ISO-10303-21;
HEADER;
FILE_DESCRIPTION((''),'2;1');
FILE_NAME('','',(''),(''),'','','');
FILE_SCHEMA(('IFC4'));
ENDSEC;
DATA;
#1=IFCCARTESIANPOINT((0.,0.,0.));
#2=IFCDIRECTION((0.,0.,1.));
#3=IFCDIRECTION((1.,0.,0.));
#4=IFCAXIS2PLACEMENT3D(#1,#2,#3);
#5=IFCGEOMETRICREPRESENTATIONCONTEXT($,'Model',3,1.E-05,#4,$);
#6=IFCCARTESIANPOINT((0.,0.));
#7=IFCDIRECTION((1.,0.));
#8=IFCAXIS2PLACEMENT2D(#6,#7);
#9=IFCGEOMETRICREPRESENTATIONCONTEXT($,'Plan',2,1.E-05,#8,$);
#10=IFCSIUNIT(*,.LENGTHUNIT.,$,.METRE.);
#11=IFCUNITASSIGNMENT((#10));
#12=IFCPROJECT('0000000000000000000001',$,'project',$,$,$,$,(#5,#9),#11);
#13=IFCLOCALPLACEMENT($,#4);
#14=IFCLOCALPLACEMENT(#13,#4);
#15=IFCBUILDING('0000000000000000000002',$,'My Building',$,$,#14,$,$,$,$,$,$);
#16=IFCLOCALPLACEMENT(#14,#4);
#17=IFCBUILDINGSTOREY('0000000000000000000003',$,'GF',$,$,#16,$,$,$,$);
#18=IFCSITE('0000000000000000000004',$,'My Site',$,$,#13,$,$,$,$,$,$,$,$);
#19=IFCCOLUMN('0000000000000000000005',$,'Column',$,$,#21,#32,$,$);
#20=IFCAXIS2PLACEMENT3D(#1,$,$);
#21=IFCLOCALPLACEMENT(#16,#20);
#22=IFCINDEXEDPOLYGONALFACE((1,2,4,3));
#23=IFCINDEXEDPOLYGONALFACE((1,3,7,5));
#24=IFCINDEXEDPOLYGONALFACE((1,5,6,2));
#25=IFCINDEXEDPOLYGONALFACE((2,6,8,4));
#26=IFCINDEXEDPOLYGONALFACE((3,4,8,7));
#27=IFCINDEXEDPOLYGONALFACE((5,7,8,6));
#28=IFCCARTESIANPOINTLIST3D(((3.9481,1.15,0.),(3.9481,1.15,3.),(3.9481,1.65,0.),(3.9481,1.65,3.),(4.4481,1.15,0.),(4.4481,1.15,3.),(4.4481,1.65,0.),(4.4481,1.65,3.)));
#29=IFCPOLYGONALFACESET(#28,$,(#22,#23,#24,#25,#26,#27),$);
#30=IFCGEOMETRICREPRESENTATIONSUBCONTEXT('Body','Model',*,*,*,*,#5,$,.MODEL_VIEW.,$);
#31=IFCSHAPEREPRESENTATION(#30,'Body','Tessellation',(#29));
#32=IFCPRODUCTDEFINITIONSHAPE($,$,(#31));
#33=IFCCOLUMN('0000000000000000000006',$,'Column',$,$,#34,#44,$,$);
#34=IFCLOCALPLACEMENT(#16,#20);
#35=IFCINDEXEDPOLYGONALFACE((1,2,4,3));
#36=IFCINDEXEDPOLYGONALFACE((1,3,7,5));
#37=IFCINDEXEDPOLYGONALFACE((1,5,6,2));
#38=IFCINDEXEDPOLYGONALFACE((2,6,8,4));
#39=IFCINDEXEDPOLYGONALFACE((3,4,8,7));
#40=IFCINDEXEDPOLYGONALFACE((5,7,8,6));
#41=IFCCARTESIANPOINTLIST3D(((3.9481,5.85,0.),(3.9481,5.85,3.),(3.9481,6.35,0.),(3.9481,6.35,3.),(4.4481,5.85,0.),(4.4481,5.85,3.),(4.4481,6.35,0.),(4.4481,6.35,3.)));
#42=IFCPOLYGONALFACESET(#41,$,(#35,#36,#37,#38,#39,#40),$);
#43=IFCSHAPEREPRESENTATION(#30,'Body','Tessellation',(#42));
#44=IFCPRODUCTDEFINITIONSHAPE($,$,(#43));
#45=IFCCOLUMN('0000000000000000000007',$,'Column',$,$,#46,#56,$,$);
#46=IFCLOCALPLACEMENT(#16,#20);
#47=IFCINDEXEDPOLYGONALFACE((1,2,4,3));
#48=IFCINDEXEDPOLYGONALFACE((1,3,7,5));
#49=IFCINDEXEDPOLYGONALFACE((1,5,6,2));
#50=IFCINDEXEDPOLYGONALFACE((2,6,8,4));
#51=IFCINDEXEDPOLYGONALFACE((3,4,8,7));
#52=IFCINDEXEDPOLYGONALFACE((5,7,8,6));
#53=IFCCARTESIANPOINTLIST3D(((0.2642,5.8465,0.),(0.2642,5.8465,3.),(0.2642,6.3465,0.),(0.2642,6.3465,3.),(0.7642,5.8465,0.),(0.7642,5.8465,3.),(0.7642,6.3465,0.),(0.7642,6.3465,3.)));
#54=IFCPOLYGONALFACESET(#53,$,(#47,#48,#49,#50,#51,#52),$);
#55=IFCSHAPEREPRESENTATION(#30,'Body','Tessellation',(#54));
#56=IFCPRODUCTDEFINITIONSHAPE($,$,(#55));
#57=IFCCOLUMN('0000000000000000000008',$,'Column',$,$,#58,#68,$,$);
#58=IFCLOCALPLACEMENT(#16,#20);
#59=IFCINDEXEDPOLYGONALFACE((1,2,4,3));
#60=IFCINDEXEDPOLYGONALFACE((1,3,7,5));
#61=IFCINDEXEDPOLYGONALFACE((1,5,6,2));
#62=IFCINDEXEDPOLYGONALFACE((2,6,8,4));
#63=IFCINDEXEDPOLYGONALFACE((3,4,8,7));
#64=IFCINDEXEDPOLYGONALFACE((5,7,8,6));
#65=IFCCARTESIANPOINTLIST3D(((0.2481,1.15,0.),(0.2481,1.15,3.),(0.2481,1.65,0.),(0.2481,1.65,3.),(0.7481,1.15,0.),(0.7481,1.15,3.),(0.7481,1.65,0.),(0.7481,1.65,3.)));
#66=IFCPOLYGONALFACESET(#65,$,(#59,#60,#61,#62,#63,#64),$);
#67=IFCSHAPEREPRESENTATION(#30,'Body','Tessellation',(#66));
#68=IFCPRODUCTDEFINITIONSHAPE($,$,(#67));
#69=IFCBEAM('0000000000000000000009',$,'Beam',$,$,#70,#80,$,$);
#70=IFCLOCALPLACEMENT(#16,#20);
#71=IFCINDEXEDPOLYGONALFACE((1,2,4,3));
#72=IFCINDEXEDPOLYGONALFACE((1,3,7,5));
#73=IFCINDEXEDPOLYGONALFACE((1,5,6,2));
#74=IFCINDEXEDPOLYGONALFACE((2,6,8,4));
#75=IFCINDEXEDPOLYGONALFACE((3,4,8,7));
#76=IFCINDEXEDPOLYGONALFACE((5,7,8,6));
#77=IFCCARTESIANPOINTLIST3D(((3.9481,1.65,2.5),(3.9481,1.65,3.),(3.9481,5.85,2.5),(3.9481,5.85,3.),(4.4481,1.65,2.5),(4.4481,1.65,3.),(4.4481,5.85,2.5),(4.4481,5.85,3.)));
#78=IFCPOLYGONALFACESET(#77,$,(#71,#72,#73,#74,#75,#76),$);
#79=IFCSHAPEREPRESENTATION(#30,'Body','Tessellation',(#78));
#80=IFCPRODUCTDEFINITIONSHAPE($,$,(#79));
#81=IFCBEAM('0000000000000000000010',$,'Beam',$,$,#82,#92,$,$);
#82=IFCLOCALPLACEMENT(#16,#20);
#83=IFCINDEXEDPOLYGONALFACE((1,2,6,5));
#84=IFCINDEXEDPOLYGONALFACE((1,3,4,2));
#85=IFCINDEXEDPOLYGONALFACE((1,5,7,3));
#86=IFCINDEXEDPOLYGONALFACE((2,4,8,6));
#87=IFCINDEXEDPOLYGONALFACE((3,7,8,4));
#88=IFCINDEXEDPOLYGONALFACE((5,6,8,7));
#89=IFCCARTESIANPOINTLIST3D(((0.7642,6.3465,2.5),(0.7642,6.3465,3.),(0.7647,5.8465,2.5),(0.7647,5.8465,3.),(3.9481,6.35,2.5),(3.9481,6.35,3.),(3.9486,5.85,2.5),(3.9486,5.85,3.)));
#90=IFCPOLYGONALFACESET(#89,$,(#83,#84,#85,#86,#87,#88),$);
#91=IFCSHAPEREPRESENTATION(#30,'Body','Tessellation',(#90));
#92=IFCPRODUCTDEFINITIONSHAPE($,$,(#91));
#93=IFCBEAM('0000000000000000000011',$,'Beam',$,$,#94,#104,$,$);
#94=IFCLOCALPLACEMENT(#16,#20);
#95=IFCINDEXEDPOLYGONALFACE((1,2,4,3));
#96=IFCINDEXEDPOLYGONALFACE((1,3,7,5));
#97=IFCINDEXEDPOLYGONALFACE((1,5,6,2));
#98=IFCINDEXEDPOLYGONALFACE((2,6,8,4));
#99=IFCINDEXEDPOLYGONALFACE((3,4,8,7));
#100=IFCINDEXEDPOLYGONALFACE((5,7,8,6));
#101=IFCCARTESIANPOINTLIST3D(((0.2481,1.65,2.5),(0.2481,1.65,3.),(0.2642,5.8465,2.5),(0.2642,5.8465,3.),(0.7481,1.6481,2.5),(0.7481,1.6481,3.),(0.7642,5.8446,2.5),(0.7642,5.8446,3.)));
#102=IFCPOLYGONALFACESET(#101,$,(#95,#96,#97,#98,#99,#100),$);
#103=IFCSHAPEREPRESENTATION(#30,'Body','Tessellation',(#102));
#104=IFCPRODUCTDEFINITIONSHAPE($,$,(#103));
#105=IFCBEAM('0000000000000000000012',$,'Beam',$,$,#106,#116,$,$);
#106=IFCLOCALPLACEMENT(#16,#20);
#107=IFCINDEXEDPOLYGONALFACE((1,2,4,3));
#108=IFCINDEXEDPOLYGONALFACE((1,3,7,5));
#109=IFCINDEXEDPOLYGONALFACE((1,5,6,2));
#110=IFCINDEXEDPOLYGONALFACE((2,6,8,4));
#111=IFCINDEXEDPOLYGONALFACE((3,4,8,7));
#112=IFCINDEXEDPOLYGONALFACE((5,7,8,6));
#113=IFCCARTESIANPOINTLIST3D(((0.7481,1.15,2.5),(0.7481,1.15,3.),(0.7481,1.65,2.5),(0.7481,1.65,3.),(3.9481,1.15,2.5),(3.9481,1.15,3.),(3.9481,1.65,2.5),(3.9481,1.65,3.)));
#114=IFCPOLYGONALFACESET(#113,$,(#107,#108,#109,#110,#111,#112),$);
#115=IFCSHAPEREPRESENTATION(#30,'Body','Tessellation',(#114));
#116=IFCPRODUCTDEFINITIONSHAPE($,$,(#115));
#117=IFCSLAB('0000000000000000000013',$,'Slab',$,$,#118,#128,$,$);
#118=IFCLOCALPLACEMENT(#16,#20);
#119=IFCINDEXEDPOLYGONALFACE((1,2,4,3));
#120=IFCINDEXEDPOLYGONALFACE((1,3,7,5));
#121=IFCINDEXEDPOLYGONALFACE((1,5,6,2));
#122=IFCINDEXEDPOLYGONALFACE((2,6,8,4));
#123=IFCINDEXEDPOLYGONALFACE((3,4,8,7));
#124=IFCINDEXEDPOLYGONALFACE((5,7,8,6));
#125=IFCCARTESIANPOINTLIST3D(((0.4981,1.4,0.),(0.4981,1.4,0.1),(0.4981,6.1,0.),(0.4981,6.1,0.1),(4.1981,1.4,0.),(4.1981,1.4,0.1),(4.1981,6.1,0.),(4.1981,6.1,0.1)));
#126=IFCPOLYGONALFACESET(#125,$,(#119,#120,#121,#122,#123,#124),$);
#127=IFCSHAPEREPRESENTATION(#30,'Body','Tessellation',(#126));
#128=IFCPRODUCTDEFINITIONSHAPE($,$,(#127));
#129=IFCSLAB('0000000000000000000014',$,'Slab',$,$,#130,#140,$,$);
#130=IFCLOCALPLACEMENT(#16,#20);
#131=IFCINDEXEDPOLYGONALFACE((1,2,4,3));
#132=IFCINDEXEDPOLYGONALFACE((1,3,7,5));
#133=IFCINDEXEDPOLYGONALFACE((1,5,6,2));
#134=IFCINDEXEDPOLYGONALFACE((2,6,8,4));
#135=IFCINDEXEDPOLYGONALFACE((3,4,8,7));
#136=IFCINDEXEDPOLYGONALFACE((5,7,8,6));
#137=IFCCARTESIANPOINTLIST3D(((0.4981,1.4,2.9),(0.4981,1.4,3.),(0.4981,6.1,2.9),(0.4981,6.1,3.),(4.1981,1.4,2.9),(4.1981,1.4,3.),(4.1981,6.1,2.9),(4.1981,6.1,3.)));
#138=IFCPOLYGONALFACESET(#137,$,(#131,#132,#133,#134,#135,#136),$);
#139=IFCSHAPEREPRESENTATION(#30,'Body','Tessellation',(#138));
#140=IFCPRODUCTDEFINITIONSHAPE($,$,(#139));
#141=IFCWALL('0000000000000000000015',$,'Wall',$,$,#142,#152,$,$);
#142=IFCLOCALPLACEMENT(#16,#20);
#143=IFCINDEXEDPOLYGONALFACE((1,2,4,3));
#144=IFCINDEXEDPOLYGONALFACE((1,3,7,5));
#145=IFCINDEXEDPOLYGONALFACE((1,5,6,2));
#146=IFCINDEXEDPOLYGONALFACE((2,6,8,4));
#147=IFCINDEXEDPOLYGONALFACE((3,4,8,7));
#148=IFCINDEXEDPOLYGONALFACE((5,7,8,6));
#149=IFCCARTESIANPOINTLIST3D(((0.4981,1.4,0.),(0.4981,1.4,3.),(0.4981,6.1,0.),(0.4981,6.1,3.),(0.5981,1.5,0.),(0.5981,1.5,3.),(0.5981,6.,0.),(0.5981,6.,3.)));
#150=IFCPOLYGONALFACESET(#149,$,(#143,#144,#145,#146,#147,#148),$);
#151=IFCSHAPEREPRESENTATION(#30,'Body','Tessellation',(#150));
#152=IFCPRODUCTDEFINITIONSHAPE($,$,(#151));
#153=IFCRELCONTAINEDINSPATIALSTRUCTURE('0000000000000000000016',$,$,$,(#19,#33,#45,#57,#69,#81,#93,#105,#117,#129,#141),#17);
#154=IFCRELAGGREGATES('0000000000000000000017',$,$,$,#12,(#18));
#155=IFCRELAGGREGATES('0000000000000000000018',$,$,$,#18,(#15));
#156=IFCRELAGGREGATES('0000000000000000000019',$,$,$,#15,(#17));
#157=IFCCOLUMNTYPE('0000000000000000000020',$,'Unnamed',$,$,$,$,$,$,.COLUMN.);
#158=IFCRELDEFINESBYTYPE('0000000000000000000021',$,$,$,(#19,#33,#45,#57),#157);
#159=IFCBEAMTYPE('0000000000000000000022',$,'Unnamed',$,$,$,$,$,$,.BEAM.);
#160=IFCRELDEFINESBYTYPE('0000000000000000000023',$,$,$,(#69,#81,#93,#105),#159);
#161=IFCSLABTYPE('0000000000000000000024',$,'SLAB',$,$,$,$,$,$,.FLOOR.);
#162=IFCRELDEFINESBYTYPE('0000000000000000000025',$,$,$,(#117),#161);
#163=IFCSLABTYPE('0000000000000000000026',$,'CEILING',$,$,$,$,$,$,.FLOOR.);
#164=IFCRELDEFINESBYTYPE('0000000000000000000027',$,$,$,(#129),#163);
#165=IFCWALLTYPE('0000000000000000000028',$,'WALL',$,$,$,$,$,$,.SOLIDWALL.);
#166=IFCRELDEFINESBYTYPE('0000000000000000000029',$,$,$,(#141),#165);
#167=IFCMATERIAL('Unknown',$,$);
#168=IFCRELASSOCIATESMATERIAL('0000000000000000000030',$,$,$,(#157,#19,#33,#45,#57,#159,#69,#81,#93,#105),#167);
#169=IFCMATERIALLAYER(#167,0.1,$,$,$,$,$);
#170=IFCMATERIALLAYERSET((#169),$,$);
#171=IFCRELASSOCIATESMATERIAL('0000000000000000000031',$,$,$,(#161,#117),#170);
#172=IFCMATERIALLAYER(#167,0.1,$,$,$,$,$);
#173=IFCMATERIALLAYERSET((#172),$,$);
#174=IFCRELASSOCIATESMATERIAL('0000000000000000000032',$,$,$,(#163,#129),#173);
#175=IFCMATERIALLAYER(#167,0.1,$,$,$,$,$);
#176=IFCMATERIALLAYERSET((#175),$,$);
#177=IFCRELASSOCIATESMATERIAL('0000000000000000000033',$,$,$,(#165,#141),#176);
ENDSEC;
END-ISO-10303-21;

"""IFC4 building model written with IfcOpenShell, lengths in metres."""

from ifc_helpers import new_model, si_unit, frame, origin_with_axes, origin_2d_with_axis, place, context, subcontext, project, spatial, line, indexed_curve, rectangle, outline, extrude, material, layer, layer_set, layer_usage, material_profile, profile_set, profile_usage, type_object, element, save


model = new_model("IFC4")

# Units and contexts
model_context = context("Model", 3, precision=1e-05, world=origin_with_axes())
plan_context = context("Plan", 2, precision=1e-05, world=origin_2d_with_axis())
body_context_1 = subcontext(model_context, "Body", "Model", "MODEL_VIEW")
ifc_project = project(units=[si_unit("LENGTHUNIT", "METRE")], contexts=[model_context, plan_context])

# Site, building, storey
site_placement = place(None, origin_with_axes())
site = spatial("IfcSite", under=ifc_project, at=site_placement, Name="My Site")
building_placement = place(site_placement, origin_with_axes())
building = spatial("IfcBuilding", under=site, at=building_placement, Name="My Building")
storey_placement = place(building_placement, origin_with_axes())
storey = spatial("IfcBuildingStorey", under=building, at=storey_placement, Name="GF")

# Columns
ifc_material = material(Name="Unknown")
ifc_material_profile_1 = material_profile(ifc_material, rectangle(XDim=0.5, YDim=0.5))
ifc_profile_set_1 = profile_set([ifc_material_profile_1])
ifc_profile_usage_1 = profile_usage(ifc_profile_set_1, cardinal=5)
column_type = type_object("IfcColumnType", Name="Unnamed", PredefinedType="COLUMN", material=ifc_profile_set_1)
column_1_placement = place(storey_placement, frame((4.1981, 1.4, 0.0), z_axis=(0.0, 0.0, 1.0), x_axis=(1.0, 0.0, 0.0)))
element("IfcColumn", 1, at=column_1_placement, inside=storey, type_object=column_type, material=ifc_profile_usage_1, Name="Column", context=body_context_1, shape_type="SweptSolid", body=[
    extrude(rectangle(XDim=0.5, YDim=0.5), origin_with_axes(), (0.0, 0.0, 1.0), 3.0),
])
ifc_profile_usage_2 = profile_usage(ifc_profile_set_1, cardinal=5)
column_2_placement = place(storey_placement, frame((4.1981, 6.1, 0.0), z_axis=(0.0, 0.0, 1.0), x_axis=(1.0, 0.0, 0.0)))
element("IfcColumn", 2, at=column_2_placement, inside=storey, type_object=column_type, material=ifc_profile_usage_2, Name="Column", context=body_context_1, shape_type="SweptSolid", body=[
    extrude(rectangle(XDim=0.5, YDim=0.5), origin_with_axes(), (0.0, 0.0, 1.0), 3.0),
])
ifc_profile_usage_3 = profile_usage(ifc_profile_set_1, cardinal=5)
column_3_placement = place(storey_placement, frame((0.5142, 6.0965, 0.0), z_axis=(0.0, 0.0, 1.0), x_axis=(1.0, 0.0, 0.0)))
element("IfcColumn", 3, at=column_3_placement, inside=storey, type_object=column_type, material=ifc_profile_usage_3, Name="Column", context=body_context_1, shape_type="SweptSolid", body=[
    extrude(rectangle(XDim=0.5, YDim=0.5), origin_with_axes(), (0.0, 0.0, 1.0), 3.0),
])
ifc_profile_usage_4 = profile_usage(ifc_profile_set_1, cardinal=5)
column_4_placement = place(storey_placement, frame((0.4981, 1.4, 0.0), z_axis=(0.0, 0.0, 1.0), x_axis=(1.0, 0.0, 0.0)))
element("IfcColumn", 4, at=column_4_placement, inside=storey, type_object=column_type, material=ifc_profile_usage_4, Name="Column", context=body_context_1, shape_type="SweptSolid", body=[
    extrude(rectangle(XDim=0.5, YDim=0.5), origin_with_axes(), (0.0, 0.0, 1.0), 3.0),
])

# Beams
ifc_material_profile_2 = material_profile(ifc_material, rectangle(XDim=0.5, YDim=0.5))
ifc_profile_set_2 = profile_set([ifc_material_profile_2])
ifc_profile_usage_5 = profile_usage(ifc_profile_set_2, cardinal=9)
beam_type = type_object("IfcBeamType", Name="Unnamed", PredefinedType="BEAM", material=ifc_profile_set_2)
beam_1_placement = place(storey_placement, frame((4.4481, 1.65, 3.0), z_axis=(0.0, 1.0, 0.0), x_axis=(-1.0, 0.0, 0.0)))
element("IfcBeam", 5, at=beam_1_placement, inside=storey, type_object=beam_type, material=ifc_profile_usage_5, Name="Beam", context=body_context_1, shape_type="SweptSolid", body=[
    extrude(rectangle(XDim=0.5, YDim=0.5), frame((0.25, -0.25, 0.0), z_axis=(0.0, 0.0, 1.0), x_axis=(1.0, 0.0, 0.0)), (0.0, 0.0, 1.0), 4.2),
])
ifc_profile_usage_6 = profile_usage(ifc_profile_set_2, cardinal=9)
beam_2_placement = place(storey_placement, frame((3.9481, 6.35, 3.0), z_axis=(-0.999999, -0.001087, 0.0), x_axis=(0.001087, -0.999999, 0.0)))
element("IfcBeam", 6, at=beam_2_placement, inside=storey, type_object=beam_type, material=ifc_profile_usage_6, Name="Beam", context=body_context_1, shape_type="SweptSolid", body=[
    extrude(rectangle(XDim=0.5, YDim=0.5), frame((0.25, -0.25, 0.0), z_axis=(0.0, 0.0, 1.0), x_axis=(1.0, 0.0, 0.0)), (0.0, 0.0, 1.0), 3.1839),
])
ifc_profile_usage_7 = profile_usage(ifc_profile_set_2, cardinal=9)
beam_3_placement = place(storey_placement, frame((0.2642, 5.8465, 3.0), z_axis=(-0.003843, -0.999993, 0.0), x_axis=(0.999993, -0.003843, 0.0)))
element("IfcBeam", 7, at=beam_3_placement, inside=storey, type_object=beam_type, material=ifc_profile_usage_7, Name="Beam", context=body_context_1, shape_type="SweptSolid", body=[
    extrude(rectangle(XDim=0.5, YDim=0.5), frame((0.25, -0.25, 0.0), z_axis=(0.0, 0.0, 1.0), x_axis=(1.0, 0.0, 0.0)), (0.0, 0.0, 1.0), 4.1966),
])
ifc_profile_usage_8 = profile_usage(ifc_profile_set_2, cardinal=9)
beam_4_placement = place(storey_placement, frame((0.7481, 1.15, 3.0), z_axis=(1.0, 0.0, 0.0), x_axis=(0.0, 1.0, 0.0)))
element("IfcBeam", 8, at=beam_4_placement, inside=storey, type_object=beam_type, material=ifc_profile_usage_8, Name="Beam", context=body_context_1, shape_type="SweptSolid", body=[
    extrude(rectangle(XDim=0.5, YDim=0.5), frame((0.25, -0.25, 0.0), z_axis=(0.0, 0.0, 1.0), x_axis=(1.0, 0.0, 0.0)), (0.0, 0.0, 1.0), 3.2),
])

# Slabs
ifc_layer_1 = layer(ifc_material, 0.1)
ifc_layer_set_1 = layer_set([ifc_layer_1])
ifc_layer_usage_1 = layer_usage(ifc_layer_set_1, "AXIS3", "POSITIVE", -0.1)
slab_type_1 = type_object("IfcSlabType", Name="SLAB", PredefinedType="FLOOR", material=ifc_layer_set_1)
slab_1_placement = place(storey_placement, frame((4.1981, 1.4, 0.1), z_axis=(0.0, 0.0, 1.0), x_axis=(1.0, 0.0, 0.0)))
element("IfcSlab", 9, at=slab_1_placement, inside=storey, type_object=slab_type_1, material=ifc_layer_usage_1, Name="Slab", context=body_context_1, shape_type="SweptSolid", body=[
    extrude(outline(indexed_curve([(0.0, 0.0), (0.0, 4.7), (-3.7, 4.7), (-3.7, 0.0), (0.0, 0.0)])), frame((0.0, 0.0, -0.1), z_axis=(0.0, 0.0, 1.0), x_axis=(1.0, 0.0, 0.0)), (0.0, 0.0, 1.0), 0.1),
])
ifc_layer_2 = layer(ifc_material, 0.1)
ifc_layer_set_2 = layer_set([ifc_layer_2])
ifc_layer_usage_2 = layer_usage(ifc_layer_set_2, "AXIS3", "POSITIVE", -0.1)
slab_type_2 = type_object("IfcSlabType", Name="CEILING", PredefinedType="FLOOR", material=ifc_layer_set_2)
slab_2_placement = place(storey_placement, frame((4.1981, 6.1, 3.0), z_axis=(0.0, 0.0, 1.0), x_axis=(1.0, 0.0, 0.0)))
element("IfcSlab", 10, at=slab_2_placement, inside=storey, type_object=slab_type_2, material=ifc_layer_usage_2, Name="Slab", context=body_context_1, shape_type="SweptSolid", body=[
    extrude(outline(indexed_curve([(0.0, 0.0), (0.0, -4.7), (-3.7, -4.7), (-3.7, 0.0), (0.0, 0.0)])), frame((0.0, 0.0, -0.1), z_axis=(0.0, 0.0, 1.0), x_axis=(1.0, 0.0, 0.0)), (0.0, 0.0, 1.0), 0.1),
])

# Wall
ifc_layer_3 = layer(ifc_material, 0.1)
ifc_layer_set_3 = layer_set([ifc_layer_3])
ifc_layer_usage_3 = layer_usage(ifc_layer_set_3, "AXIS2", "POSITIVE", 0.0)
wall_type_1 = type_object("IfcWallType", Name="WALL", PredefinedType="SOLIDWALL", material=ifc_layer_set_3)
wall_1_placement = place(storey_placement, frame((0.5981, 1.5, 0.0), z_axis=(0.0, 0.0, 1.0), x_axis=(0.0, 1.0, 0.0)))
element("IfcWall", 11, at=wall_1_placement, inside=storey, type_object=wall_type_1, material=ifc_layer_usage_3, Name="Wall", context=body_context_1, shape_type="SweptSolid", body=[
    extrude(outline(indexed_curve([(0.0, 0.0), (-0.1, 0.1), (4.6, 0.1), (4.5, 0.0)], segments=[line(1, 2, 3, 4, 1)])), origin_with_axes(), (0.0, 0.0, 1.0), 3.0),
])

save(model, "model.ifc")
